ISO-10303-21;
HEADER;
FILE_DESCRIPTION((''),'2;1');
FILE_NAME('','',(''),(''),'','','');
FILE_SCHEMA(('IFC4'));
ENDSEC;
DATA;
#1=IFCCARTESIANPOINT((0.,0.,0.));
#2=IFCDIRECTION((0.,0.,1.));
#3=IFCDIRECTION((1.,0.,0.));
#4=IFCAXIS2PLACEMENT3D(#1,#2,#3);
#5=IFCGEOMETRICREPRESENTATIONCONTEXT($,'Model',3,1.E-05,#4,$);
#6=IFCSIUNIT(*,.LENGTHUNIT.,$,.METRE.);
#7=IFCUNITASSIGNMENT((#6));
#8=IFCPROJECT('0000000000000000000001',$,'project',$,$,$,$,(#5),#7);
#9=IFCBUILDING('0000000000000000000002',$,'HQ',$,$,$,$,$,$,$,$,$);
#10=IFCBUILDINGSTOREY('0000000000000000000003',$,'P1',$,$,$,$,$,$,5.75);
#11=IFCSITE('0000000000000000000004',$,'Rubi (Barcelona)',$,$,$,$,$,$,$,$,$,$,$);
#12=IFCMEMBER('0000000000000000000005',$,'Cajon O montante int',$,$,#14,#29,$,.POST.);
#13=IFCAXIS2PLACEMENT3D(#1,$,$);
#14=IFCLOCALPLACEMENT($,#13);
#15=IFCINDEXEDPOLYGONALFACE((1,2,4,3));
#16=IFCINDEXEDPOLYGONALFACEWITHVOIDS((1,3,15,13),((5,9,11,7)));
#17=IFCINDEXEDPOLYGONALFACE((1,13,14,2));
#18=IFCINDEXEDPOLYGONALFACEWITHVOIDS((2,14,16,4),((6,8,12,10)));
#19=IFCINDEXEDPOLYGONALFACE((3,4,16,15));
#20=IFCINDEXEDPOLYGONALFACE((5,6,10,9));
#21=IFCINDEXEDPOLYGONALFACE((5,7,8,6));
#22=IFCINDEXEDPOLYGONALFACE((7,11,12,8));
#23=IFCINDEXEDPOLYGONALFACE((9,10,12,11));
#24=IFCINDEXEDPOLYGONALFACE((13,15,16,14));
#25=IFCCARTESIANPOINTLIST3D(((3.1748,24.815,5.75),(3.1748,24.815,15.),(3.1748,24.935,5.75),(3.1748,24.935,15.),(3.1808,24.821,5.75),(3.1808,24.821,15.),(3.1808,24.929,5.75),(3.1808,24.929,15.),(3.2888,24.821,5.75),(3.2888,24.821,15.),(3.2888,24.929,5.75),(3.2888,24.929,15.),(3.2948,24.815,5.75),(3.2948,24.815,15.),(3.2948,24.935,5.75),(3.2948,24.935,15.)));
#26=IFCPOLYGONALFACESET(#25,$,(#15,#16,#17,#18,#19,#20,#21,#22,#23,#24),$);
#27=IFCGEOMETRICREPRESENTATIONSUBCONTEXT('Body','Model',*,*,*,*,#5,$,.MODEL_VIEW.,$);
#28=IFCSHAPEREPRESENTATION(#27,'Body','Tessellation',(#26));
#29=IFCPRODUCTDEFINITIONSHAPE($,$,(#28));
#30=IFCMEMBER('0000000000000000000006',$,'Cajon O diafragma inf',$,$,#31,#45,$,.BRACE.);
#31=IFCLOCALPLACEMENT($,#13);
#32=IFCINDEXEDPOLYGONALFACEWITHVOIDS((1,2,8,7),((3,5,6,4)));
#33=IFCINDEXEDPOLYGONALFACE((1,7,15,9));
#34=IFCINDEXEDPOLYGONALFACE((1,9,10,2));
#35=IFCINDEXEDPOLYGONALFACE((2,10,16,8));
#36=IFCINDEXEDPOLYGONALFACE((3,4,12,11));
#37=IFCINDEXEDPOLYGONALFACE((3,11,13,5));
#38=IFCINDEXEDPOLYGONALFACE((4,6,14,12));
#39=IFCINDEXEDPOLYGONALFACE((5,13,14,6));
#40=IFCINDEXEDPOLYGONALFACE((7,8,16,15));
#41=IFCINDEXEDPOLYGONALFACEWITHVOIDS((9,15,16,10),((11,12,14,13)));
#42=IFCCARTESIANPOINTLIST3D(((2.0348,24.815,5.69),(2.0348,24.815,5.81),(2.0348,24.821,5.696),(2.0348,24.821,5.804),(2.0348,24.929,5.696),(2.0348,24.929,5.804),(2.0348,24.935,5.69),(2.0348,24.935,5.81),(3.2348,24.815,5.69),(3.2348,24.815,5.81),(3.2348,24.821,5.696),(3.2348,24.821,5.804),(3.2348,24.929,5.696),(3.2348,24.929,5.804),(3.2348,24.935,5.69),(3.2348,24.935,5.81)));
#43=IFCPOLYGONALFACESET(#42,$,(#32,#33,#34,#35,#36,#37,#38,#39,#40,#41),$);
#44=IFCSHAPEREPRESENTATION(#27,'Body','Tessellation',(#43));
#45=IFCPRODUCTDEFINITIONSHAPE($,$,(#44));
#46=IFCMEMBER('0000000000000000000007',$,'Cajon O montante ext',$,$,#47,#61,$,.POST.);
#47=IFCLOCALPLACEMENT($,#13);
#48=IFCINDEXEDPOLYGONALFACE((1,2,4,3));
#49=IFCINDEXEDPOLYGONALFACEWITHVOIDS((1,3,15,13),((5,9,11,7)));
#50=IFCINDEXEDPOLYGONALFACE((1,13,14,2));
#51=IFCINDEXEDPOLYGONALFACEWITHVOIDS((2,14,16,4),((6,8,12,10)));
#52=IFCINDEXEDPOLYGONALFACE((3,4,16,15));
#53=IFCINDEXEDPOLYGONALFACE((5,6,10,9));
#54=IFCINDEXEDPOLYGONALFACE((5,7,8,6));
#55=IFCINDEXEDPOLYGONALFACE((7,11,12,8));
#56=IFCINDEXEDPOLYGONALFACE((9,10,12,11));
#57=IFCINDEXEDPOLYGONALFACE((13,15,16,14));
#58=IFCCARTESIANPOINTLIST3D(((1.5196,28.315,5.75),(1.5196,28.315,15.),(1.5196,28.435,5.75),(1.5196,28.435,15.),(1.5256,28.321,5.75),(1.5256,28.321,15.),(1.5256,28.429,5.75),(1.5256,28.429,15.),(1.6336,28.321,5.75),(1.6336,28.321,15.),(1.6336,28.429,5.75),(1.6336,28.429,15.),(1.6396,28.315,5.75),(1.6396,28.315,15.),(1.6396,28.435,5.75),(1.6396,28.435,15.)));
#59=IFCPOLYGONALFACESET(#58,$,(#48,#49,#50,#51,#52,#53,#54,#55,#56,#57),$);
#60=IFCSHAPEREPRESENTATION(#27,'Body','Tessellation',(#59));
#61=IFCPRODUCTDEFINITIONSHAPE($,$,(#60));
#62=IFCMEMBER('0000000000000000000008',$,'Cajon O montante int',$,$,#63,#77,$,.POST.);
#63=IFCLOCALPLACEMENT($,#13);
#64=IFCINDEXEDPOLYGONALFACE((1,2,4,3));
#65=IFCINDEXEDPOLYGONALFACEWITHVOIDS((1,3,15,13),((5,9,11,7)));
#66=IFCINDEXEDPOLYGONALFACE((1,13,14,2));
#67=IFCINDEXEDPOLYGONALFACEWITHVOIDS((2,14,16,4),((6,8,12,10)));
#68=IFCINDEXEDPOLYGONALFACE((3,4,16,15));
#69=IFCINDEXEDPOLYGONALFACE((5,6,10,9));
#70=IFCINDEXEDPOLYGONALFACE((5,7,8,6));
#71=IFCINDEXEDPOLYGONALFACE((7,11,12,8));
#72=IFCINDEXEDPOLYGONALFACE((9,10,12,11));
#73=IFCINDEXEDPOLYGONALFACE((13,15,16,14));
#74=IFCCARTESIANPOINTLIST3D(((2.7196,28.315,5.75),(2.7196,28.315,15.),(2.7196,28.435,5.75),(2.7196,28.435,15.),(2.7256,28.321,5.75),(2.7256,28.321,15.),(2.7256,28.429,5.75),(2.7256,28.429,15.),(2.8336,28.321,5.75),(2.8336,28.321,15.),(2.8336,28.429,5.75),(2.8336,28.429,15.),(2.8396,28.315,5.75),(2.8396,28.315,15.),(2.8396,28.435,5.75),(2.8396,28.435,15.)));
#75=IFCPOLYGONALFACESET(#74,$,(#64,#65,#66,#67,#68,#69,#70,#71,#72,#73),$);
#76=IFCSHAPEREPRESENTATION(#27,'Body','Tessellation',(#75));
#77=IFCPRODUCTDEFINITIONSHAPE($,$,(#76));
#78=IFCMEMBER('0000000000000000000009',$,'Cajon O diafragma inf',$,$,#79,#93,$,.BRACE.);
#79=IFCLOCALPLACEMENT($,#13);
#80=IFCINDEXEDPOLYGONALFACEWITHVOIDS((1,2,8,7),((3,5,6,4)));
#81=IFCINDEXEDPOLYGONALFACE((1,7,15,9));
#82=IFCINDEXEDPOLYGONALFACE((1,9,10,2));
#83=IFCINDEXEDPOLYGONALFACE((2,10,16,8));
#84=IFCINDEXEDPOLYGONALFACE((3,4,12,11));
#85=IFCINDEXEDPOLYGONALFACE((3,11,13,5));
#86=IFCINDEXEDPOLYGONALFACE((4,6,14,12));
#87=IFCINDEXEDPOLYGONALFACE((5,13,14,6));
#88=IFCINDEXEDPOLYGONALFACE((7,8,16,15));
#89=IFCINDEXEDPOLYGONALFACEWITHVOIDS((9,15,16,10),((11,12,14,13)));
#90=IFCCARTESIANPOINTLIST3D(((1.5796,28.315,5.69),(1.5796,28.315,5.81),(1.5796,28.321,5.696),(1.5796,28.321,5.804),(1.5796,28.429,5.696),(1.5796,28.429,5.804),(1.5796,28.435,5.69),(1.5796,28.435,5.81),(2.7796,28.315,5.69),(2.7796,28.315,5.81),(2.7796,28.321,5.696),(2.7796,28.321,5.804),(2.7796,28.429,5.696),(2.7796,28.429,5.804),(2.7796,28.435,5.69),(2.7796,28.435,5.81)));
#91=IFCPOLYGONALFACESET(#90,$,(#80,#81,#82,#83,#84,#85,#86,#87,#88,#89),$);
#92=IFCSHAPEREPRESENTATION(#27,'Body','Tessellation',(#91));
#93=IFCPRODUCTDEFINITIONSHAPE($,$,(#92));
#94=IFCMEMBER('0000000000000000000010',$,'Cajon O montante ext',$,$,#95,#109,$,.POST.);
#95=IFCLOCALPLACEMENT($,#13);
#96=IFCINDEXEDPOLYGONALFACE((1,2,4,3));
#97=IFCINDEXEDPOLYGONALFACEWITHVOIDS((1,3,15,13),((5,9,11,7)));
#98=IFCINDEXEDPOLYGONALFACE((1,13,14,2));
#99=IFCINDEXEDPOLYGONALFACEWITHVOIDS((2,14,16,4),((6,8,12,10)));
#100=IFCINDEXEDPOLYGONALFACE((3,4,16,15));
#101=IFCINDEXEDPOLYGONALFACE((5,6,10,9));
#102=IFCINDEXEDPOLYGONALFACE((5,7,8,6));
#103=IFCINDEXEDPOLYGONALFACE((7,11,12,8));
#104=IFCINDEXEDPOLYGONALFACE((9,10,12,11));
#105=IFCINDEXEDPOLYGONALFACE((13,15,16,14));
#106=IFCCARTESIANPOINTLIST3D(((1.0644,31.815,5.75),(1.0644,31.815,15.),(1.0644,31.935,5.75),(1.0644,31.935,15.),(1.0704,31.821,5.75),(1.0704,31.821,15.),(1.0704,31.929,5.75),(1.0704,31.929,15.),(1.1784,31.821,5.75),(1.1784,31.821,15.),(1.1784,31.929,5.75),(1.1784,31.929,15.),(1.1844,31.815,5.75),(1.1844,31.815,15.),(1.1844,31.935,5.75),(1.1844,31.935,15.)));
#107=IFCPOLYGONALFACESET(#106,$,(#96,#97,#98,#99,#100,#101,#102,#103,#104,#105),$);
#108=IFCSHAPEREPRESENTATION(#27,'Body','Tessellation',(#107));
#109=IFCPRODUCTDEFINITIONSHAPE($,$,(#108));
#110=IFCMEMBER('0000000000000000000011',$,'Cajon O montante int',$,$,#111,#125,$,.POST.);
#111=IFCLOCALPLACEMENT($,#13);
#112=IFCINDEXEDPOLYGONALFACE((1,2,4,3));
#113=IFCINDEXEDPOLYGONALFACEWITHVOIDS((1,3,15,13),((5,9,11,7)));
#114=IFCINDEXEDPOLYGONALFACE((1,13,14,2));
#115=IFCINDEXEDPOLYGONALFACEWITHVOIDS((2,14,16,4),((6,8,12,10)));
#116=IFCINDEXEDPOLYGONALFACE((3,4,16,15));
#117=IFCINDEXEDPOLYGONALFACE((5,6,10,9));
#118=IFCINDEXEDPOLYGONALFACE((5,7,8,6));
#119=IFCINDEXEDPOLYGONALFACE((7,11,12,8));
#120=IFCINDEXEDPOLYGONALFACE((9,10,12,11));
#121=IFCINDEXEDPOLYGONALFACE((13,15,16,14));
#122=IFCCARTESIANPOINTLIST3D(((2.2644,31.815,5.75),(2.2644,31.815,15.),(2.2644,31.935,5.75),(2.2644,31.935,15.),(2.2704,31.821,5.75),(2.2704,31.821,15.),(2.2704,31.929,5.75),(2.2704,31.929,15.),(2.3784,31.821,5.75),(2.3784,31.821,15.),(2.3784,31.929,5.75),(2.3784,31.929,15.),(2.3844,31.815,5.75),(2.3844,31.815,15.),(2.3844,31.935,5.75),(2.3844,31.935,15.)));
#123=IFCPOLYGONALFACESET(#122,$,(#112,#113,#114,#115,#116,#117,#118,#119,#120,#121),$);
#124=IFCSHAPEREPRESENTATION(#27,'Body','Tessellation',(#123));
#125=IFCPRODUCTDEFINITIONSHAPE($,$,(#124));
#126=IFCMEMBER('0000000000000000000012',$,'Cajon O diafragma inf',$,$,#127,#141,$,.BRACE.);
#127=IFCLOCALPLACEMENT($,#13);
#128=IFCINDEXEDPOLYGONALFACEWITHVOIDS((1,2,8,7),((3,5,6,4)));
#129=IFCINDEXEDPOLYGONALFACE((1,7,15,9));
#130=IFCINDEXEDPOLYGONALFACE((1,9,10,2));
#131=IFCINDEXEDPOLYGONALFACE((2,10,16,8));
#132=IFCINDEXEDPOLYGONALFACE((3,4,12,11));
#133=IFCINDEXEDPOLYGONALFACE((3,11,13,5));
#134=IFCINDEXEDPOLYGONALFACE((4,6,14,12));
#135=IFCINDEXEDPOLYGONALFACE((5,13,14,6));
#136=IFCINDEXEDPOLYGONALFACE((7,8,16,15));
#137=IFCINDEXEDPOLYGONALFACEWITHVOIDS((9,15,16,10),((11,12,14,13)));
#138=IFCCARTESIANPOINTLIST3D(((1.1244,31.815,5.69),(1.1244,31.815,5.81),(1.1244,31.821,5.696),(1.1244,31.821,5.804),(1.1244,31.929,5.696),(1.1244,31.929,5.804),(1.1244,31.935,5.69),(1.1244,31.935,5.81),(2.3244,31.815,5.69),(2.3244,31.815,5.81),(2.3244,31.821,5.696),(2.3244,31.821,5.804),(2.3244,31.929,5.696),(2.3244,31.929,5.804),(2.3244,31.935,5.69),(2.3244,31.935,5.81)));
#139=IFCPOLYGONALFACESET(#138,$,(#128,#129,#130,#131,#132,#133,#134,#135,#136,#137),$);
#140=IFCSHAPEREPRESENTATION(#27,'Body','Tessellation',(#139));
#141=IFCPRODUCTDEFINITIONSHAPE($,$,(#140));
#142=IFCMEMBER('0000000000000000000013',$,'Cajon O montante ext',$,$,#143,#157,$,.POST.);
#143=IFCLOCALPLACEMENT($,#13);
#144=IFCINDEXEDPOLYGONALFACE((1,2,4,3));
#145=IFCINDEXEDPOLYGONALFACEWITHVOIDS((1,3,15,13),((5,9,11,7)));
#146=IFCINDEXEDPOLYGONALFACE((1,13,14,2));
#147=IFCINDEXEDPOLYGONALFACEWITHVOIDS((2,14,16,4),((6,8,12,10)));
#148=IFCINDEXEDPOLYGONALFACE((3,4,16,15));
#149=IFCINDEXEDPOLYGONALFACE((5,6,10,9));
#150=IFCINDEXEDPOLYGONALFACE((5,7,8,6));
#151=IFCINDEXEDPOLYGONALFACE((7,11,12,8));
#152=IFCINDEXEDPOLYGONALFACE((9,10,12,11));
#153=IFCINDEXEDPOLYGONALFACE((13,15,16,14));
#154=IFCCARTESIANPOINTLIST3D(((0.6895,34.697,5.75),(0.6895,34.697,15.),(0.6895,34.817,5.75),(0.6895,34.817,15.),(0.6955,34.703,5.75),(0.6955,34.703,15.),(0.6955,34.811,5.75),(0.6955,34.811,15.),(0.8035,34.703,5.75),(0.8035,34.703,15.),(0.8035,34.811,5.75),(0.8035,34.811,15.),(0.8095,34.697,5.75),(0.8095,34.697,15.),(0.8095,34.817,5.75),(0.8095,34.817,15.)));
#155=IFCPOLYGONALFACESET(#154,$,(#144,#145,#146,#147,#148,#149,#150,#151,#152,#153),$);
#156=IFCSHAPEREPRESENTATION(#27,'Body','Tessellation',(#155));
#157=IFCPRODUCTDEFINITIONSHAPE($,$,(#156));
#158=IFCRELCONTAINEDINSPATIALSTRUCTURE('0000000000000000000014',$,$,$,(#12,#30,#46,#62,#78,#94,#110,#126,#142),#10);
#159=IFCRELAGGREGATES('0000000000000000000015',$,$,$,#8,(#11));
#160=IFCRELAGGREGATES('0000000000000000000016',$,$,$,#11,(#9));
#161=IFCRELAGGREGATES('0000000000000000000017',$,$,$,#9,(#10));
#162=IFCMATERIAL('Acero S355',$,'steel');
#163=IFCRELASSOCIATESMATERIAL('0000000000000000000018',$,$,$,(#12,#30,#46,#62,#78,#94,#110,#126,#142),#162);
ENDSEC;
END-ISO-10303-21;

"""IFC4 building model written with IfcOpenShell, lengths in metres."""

from ifc_helpers import new_model, si_unit, frame, origin_with_axes, place, context, subcontext, project, spatial, hollow_rectangle, extrude, material, element, save


model = new_model("IFC4")

# Units and contexts
model_context = context("Model", 3, precision=1e-05, world=origin_with_axes())
body_context = subcontext(model_context, "Body", "Model", "MODEL_VIEW")
ifc_project = project(units=[si_unit("LENGTHUNIT", "METRE")], contexts=[model_context])

# Site, building, storey
site = spatial("IfcSite", under=ifc_project, Name="Rubi (Barcelona)")
building = spatial("IfcBuilding", under=site, Name="HQ")
storey = spatial("IfcBuildingStorey", under=building, Name="P1", Elevation=5.75)

# Members
ifc_material = material(Name="Acero S355", Category="steel")
member_1_placement = place(None, origin_with_axes())
element("IfcMember", 1, at=member_1_placement, inside=storey, material=ifc_material, Name="Cajon O montante int", PredefinedType="POST", context=body_context, shape_type="SweptSolid", body=[
    extrude(hollow_rectangle(XDim=0.12, YDim=0.12, WallThickness=0.006), frame((3.2348, 24.875, 5.75), z_axis=(0.0, 0.0, 1.0), x_axis=(1.0, 0.0, 0.0)), (0.0, 0.0, 1.0), 9.25),
])
member_2_placement = place(None, origin_with_axes())
element("IfcMember", 2, at=member_2_placement, inside=storey, material=ifc_material, Name="Cajon O diafragma inf", PredefinedType="BRACE", context=body_context, shape_type="SweptSolid", body=[
    extrude(hollow_rectangle(XDim=0.12, YDim=0.12, WallThickness=0.006), frame((2.0348, 24.875, 5.75), z_axis=(1.0, 0.0, 0.0), x_axis=(0.0, 1.0, 0.0)), (0.0, 0.0, 1.0), 1.2),
])
member_3_placement = place(None, origin_with_axes())
element("IfcMember", 3, at=member_3_placement, inside=storey, material=ifc_material, Name="Cajon O montante ext", PredefinedType="POST", context=body_context, shape_type="SweptSolid", body=[
    extrude(hollow_rectangle(XDim=0.12, YDim=0.12, WallThickness=0.006), frame((1.5796, 28.375, 5.75), z_axis=(0.0, 0.0, 1.0), x_axis=(1.0, 0.0, 0.0)), (0.0, 0.0, 1.0), 9.25),
])
member_4_placement = place(None, origin_with_axes())
element("IfcMember", 4, at=member_4_placement, inside=storey, material=ifc_material, Name="Cajon O montante int", PredefinedType="POST", context=body_context, shape_type="SweptSolid", body=[
    extrude(hollow_rectangle(XDim=0.12, YDim=0.12, WallThickness=0.006), frame((2.7796, 28.375, 5.75), z_axis=(0.0, 0.0, 1.0), x_axis=(1.0, 0.0, 0.0)), (0.0, 0.0, 1.0), 9.25),
])
member_5_placement = place(None, origin_with_axes())
element("IfcMember", 5, at=member_5_placement, inside=storey, material=ifc_material, Name="Cajon O diafragma inf", PredefinedType="BRACE", context=body_context, shape_type="SweptSolid", body=[
    extrude(hollow_rectangle(XDim=0.12, YDim=0.12, WallThickness=0.006), frame((1.5796, 28.375, 5.75), z_axis=(1.0, 0.0, 0.0), x_axis=(0.0, 1.0, 0.0)), (0.0, 0.0, 1.0), 1.2),
])
member_6_placement = place(None, origin_with_axes())
element("IfcMember", 6, at=member_6_placement, inside=storey, material=ifc_material, Name="Cajon O montante ext", PredefinedType="POST", context=body_context, shape_type="SweptSolid", body=[
    extrude(hollow_rectangle(XDim=0.12, YDim=0.12, WallThickness=0.006), frame((1.1244, 31.875, 5.75), z_axis=(0.0, 0.0, 1.0), x_axis=(1.0, 0.0, 0.0)), (0.0, 0.0, 1.0), 9.25),
])
member_7_placement = place(None, origin_with_axes())
element("IfcMember", 7, at=member_7_placement, inside=storey, material=ifc_material, Name="Cajon O montante int", PredefinedType="POST", context=body_context, shape_type="SweptSolid", body=[
    extrude(hollow_rectangle(XDim=0.12, YDim=0.12, WallThickness=0.006), frame((2.3244, 31.875, 5.75), z_axis=(0.0, 0.0, 1.0), x_axis=(1.0, 0.0, 0.0)), (0.0, 0.0, 1.0), 9.25),
])
member_8_placement = place(None, origin_with_axes())
element("IfcMember", 8, at=member_8_placement, inside=storey, material=ifc_material, Name="Cajon O diafragma inf", PredefinedType="BRACE", context=body_context, shape_type="SweptSolid", body=[
    extrude(hollow_rectangle(XDim=0.12, YDim=0.12, WallThickness=0.006), frame((1.1244, 31.875, 5.75), z_axis=(1.0, 0.0, 0.0), x_axis=(0.0, 1.0, 0.0)), (0.0, 0.0, 1.0), 1.2),
])
member_9_placement = place(None, origin_with_axes())
element("IfcMember", 9, at=member_9_placement, inside=storey, material=ifc_material, Name="Cajon O montante ext", PredefinedType="POST", context=body_context, shape_type="SweptSolid", body=[
    extrude(hollow_rectangle(XDim=0.12, YDim=0.12, WallThickness=0.006), frame((0.7495, 34.757, 5.75), z_axis=(0.0, 0.0, 1.0), x_axis=(1.0, 0.0, 0.0)), (0.0, 0.0, 1.0), 9.25),
])

save(model, "model.ifc")
